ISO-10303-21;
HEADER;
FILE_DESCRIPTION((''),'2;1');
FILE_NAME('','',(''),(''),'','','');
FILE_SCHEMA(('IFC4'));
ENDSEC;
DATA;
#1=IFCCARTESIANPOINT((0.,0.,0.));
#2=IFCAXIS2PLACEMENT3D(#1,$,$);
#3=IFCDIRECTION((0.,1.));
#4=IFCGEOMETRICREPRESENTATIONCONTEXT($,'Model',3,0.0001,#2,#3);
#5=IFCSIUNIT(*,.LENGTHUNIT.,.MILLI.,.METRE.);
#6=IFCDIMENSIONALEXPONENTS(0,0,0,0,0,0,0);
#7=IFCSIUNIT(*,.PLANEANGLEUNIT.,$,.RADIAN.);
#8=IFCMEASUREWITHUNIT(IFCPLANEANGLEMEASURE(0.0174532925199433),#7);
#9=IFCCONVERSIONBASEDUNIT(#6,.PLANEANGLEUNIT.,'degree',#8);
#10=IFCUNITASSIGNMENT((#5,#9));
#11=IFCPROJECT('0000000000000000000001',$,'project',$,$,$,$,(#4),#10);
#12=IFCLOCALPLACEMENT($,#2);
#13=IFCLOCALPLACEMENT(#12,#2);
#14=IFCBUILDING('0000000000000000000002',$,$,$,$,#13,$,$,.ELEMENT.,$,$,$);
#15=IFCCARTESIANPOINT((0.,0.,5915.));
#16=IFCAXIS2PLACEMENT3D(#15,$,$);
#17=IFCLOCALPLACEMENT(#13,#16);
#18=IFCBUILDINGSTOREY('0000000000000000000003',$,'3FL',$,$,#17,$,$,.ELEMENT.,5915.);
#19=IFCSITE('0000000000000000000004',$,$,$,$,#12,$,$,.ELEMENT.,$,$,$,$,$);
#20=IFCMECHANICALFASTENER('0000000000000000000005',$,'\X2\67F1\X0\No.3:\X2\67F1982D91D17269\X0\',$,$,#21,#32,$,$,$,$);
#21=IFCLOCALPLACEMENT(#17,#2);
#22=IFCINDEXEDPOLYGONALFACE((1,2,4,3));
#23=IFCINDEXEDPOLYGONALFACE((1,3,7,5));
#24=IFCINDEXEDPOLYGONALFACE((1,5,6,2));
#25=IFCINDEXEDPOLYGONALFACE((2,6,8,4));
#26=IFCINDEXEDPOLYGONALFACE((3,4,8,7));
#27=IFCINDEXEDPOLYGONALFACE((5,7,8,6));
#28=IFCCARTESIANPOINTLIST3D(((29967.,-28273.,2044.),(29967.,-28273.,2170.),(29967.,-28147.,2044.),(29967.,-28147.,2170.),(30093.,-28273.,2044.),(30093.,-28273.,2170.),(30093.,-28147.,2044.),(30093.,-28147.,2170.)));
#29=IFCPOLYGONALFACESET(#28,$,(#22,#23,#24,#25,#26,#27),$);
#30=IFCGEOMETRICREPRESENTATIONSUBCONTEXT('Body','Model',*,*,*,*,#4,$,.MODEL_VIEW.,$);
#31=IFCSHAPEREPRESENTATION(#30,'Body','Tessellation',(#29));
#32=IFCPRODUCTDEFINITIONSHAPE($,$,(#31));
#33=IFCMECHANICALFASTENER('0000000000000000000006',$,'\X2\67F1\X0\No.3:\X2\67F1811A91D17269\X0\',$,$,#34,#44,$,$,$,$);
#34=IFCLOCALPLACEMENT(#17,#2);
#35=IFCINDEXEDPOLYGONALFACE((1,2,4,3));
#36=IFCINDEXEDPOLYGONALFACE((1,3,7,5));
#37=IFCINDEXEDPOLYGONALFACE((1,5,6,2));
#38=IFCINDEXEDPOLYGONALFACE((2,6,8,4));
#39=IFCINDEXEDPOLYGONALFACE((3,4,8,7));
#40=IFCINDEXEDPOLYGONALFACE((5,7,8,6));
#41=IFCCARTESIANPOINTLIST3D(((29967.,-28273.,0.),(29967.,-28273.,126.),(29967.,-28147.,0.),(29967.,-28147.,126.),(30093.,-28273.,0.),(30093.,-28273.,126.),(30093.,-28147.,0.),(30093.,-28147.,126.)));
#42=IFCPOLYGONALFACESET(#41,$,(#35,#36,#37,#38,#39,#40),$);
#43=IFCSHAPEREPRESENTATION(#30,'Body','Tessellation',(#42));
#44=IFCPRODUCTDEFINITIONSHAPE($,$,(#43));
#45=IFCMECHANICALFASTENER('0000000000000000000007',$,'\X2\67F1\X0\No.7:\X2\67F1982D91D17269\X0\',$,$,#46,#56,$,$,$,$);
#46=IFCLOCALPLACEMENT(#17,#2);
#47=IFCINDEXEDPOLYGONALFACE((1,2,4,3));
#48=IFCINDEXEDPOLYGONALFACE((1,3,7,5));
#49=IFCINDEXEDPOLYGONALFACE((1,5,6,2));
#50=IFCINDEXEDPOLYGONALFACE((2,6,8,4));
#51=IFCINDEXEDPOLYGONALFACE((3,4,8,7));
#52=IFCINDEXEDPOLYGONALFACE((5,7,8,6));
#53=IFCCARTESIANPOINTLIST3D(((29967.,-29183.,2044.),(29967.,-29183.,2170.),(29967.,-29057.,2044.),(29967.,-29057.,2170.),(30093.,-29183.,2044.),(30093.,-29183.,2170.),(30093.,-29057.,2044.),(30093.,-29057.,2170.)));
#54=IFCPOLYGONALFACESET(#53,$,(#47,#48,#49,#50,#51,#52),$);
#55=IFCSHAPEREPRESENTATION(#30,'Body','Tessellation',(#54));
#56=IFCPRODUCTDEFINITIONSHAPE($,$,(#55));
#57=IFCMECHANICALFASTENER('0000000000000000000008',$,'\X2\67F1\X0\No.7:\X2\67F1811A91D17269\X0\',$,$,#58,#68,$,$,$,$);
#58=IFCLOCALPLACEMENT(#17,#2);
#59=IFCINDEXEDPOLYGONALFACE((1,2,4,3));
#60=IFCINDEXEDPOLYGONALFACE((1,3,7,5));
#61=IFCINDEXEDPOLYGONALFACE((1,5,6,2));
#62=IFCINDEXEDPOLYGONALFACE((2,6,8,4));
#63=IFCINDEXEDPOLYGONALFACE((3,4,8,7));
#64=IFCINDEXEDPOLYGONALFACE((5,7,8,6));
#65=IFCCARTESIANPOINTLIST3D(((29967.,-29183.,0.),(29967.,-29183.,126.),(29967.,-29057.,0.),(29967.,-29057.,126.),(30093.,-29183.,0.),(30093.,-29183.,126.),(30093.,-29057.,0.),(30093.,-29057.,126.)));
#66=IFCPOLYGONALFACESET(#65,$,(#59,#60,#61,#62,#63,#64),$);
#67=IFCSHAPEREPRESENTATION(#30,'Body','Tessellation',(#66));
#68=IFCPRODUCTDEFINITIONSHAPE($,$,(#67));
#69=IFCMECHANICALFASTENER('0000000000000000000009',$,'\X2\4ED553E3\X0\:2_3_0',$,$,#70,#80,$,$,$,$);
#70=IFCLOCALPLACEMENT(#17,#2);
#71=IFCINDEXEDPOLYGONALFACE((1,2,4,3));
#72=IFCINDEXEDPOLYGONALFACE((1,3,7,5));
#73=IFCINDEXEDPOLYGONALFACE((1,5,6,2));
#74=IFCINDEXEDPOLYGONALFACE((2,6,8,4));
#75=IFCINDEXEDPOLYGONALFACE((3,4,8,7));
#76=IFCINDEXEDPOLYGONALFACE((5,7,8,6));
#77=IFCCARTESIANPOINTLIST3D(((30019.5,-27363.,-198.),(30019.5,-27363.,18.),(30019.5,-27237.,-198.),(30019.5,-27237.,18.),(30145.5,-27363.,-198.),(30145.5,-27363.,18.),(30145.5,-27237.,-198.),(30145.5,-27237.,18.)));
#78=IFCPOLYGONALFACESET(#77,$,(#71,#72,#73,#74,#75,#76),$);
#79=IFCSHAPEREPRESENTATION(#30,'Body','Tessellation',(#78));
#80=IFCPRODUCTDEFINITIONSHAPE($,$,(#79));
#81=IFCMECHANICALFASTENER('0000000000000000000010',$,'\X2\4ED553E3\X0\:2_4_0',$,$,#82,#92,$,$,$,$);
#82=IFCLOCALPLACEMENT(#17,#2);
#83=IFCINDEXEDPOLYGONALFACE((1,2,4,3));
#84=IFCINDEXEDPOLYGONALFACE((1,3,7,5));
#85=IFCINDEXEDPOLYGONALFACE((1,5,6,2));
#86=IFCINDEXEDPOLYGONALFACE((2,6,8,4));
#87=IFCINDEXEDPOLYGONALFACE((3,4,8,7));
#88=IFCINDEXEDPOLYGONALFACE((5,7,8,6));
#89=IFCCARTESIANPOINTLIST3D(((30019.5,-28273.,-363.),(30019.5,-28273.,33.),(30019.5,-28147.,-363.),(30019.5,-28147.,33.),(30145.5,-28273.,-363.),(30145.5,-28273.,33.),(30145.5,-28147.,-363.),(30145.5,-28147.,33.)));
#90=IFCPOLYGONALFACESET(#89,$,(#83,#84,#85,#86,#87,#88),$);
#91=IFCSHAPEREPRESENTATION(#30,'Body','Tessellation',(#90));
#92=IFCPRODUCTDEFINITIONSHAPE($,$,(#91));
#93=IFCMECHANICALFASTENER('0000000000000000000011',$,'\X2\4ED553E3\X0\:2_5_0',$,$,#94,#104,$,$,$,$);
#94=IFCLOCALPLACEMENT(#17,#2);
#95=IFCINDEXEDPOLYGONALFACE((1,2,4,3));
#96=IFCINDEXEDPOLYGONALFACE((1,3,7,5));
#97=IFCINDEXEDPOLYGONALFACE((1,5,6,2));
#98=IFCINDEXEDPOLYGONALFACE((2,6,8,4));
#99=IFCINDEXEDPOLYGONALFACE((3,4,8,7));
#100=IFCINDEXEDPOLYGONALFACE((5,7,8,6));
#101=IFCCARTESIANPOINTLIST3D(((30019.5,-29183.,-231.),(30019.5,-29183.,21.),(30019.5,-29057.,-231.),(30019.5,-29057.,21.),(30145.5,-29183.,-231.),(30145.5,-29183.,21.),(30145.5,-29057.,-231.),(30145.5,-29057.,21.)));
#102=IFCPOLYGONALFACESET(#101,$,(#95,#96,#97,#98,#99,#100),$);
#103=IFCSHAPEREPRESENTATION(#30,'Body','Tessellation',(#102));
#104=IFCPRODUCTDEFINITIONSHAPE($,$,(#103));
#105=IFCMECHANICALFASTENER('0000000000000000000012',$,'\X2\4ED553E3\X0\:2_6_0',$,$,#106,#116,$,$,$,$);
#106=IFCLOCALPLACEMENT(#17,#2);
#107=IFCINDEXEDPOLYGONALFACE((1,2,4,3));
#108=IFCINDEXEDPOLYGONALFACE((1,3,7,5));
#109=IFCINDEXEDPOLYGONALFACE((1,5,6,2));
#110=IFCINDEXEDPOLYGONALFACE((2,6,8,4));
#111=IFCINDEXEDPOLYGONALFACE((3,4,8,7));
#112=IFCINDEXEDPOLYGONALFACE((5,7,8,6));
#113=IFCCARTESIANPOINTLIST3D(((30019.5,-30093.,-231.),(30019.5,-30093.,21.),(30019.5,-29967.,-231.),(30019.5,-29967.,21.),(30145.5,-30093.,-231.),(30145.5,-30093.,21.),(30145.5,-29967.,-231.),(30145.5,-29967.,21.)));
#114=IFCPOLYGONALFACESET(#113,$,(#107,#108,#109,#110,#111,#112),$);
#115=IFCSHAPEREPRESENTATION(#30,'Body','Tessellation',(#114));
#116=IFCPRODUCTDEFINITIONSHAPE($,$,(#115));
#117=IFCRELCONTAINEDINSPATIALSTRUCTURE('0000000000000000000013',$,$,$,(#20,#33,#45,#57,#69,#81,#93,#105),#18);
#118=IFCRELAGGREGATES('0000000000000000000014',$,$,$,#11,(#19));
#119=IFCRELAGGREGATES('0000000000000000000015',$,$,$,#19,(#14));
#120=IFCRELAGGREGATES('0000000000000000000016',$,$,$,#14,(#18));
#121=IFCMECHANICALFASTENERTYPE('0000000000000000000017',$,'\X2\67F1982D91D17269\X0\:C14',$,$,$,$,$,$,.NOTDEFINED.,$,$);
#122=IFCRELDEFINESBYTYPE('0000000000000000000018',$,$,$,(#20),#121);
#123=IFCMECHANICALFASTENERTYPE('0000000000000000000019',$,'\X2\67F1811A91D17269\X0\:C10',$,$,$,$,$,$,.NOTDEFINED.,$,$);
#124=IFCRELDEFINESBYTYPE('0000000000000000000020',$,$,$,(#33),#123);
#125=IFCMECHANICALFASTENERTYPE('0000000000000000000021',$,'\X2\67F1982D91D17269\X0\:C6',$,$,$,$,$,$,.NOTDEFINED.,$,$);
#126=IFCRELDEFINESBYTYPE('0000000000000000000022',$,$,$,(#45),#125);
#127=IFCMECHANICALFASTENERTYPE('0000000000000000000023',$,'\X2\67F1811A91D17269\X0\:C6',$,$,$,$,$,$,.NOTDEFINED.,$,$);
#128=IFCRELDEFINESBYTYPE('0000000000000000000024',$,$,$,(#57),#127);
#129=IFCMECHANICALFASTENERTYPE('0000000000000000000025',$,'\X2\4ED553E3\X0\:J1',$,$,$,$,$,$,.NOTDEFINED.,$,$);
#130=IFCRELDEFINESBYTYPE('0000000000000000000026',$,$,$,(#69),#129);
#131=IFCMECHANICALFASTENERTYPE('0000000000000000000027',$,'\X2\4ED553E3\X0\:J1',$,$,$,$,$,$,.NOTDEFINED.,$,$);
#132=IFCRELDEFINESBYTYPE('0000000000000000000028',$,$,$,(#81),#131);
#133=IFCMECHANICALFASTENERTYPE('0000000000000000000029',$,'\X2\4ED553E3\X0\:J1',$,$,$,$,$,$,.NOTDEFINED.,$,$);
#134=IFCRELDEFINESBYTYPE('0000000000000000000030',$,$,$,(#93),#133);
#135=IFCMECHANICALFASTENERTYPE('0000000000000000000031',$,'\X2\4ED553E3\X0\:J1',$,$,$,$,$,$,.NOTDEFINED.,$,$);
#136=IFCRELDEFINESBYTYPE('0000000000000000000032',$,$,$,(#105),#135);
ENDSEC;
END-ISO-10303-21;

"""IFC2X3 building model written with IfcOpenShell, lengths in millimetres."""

from ifc_helpers import new_model, entity, si_unit, converted_unit, direction, frame, origin, origin_with_axes, origin_2d, place, context, subcontext, project, spatial, rectangle, extrude, type_object, element, save


model = new_model("IFC2X3")

# Units and contexts
model_context = context("Model", 3, precision=0.0001, world=origin(), true_north=direction((0.0, 1.0)))
body_context = subcontext(model_context, "Body", "Model", "MODEL_VIEW")
ifc_project = project(units=[si_unit("LENGTHUNIT", "METRE", prefix="MILLI"), converted_unit("PLANEANGLEUNIT", "degree", entity("IfcPlaneAngleMeasure", 0.0174532925199433), si_unit("PLANEANGLEUNIT", "RADIAN"), dimensions=[0, 0, 0, 0, 0, 0, 0])], contexts=[model_context])

# Site, building, storey
site_placement = place(None, origin())
site = spatial("IfcSite", under=ifc_project, at=site_placement, CompositionType="ELEMENT")
building_placement = place(site_placement, origin())
building = spatial("IfcBuilding", under=site, at=building_placement, CompositionType="ELEMENT")
storey_placement = place(building_placement, frame((0.0, 0.0, 5915.0)))
storey = spatial("IfcBuildingStorey", under=building, at=storey_placement, Name="3FL", CompositionType="ELEMENT", Elevation=5915.0)

# Mechanical fasteners
mechanical_fastener_type_1 = type_object("IfcMechanicalFastenerType", Name="柱頭金物:C14")
mechanical_fastener_1_placement = place(storey_placement, frame((30030.0, -28210.0, 2044.0)))
element("IfcMechanicalFastener", 1, at=mechanical_fastener_1_placement, inside=storey, type_object=mechanical_fastener_type_1, Name="柱No.3:柱頭金物", context=body_context, shape_type="SweptSolid", body=[
    extrude(rectangle(XDim=126.0, YDim=126.0, at=origin_2d()), origin_with_axes(), (0.0, 0.0, 1.0), 126.0),
])
mechanical_fastener_type_2 = type_object("IfcMechanicalFastenerType", Name="柱脚金物:C10")
mechanical_fastener_2_placement = place(storey_placement, frame((30030.0, -28210.0, 0.0)))
element("IfcMechanicalFastener", 2, at=mechanical_fastener_2_placement, inside=storey, type_object=mechanical_fastener_type_2, Name="柱No.3:柱脚金物", context=body_context, shape_type="SweptSolid", body=[
    extrude(rectangle(XDim=126.0, YDim=126.0, at=origin_2d()), origin_with_axes(), (0.0, 0.0, 1.0), 126.0),
])
mechanical_fastener_type_3 = type_object("IfcMechanicalFastenerType", Name="柱頭金物:C6")
mechanical_fastener_3_placement = place(storey_placement, frame((30030.0, -29120.0, 2044.0)))
element("IfcMechanicalFastener", 3, at=mechanical_fastener_3_placement, inside=storey, type_object=mechanical_fastener_type_3, Name="柱No.7:柱頭金物", context=body_context, shape_type="SweptSolid", body=[
    extrude(rectangle(XDim=126.0, YDim=126.0, at=origin_2d()), origin_with_axes(), (0.0, 0.0, 1.0), 126.0),
])
mechanical_fastener_type_4 = type_object("IfcMechanicalFastenerType", Name="柱脚金物:C6")
mechanical_fastener_4_placement = place(storey_placement, frame((30030.0, -29120.0, 0.0)))
element("IfcMechanicalFastener", 4, at=mechanical_fastener_4_placement, inside=storey, type_object=mechanical_fastener_type_4, Name="柱No.7:柱脚金物", context=body_context, shape_type="SweptSolid", body=[
    extrude(rectangle(XDim=126.0, YDim=126.0, at=origin_2d()), origin_with_axes(), (0.0, 0.0, 1.0), 126.0),
])
mechanical_fastener_type_5 = type_object("IfcMechanicalFastenerType", Name="仕口:J1")
mechanical_fastener_5_placement = place(storey_placement, frame((30082.5, -27300.0, -198.0)))
element("IfcMechanicalFastener", 5, at=mechanical_fastener_5_placement, inside=storey, type_object=mechanical_fastener_type_5, Name="仕口:2_3_0", context=body_context, shape_type="SweptSolid", body=[
    extrude(rectangle(XDim=126.0, YDim=126.0, at=origin_2d()), origin_with_axes(), (0.0, 0.0, 1.0), 216.0),
])
mechanical_fastener_type_6 = type_object("IfcMechanicalFastenerType", Name="仕口:J1")
mechanical_fastener_6_placement = place(storey_placement, frame((30082.5, -28210.0, -363.0)))
element("IfcMechanicalFastener", 6, at=mechanical_fastener_6_placement, inside=storey, type_object=mechanical_fastener_type_6, Name="仕口:2_4_0", context=body_context, shape_type="SweptSolid", body=[
    extrude(rectangle(XDim=126.0, YDim=126.0, at=origin_2d()), origin_with_axes(), (0.0, 0.0, 1.0), 396.0),
])
mechanical_fastener_type_7 = type_object("IfcMechanicalFastenerType", Name="仕口:J1")
mechanical_fastener_7_placement = place(storey_placement, frame((30082.5, -29120.0, -231.0)))
element("IfcMechanicalFastener", 7, at=mechanical_fastener_7_placement, inside=storey, type_object=mechanical_fastener_type_7, Name="仕口:2_5_0", context=body_context, shape_type="SweptSolid", body=[
    extrude(rectangle(XDim=126.0, YDim=126.0, at=origin_2d()), origin_with_axes(), (0.0, 0.0, 1.0), 252.0),
])
mechanical_fastener_type_8 = type_object("IfcMechanicalFastenerType", Name="仕口:J1")
mechanical_fastener_8_placement = place(storey_placement, frame((30082.5, -30030.0, -231.0)))
element("IfcMechanicalFastener", 8, at=mechanical_fastener_8_placement, inside=storey, type_object=mechanical_fastener_type_8, Name="仕口:2_6_0", context=body_context, shape_type="SweptSolid", body=[
    extrude(rectangle(XDim=126.0, YDim=126.0, at=origin_2d()), origin_with_axes(), (0.0, 0.0, 1.0), 252.0),
])

save(model, "model.ifc")
